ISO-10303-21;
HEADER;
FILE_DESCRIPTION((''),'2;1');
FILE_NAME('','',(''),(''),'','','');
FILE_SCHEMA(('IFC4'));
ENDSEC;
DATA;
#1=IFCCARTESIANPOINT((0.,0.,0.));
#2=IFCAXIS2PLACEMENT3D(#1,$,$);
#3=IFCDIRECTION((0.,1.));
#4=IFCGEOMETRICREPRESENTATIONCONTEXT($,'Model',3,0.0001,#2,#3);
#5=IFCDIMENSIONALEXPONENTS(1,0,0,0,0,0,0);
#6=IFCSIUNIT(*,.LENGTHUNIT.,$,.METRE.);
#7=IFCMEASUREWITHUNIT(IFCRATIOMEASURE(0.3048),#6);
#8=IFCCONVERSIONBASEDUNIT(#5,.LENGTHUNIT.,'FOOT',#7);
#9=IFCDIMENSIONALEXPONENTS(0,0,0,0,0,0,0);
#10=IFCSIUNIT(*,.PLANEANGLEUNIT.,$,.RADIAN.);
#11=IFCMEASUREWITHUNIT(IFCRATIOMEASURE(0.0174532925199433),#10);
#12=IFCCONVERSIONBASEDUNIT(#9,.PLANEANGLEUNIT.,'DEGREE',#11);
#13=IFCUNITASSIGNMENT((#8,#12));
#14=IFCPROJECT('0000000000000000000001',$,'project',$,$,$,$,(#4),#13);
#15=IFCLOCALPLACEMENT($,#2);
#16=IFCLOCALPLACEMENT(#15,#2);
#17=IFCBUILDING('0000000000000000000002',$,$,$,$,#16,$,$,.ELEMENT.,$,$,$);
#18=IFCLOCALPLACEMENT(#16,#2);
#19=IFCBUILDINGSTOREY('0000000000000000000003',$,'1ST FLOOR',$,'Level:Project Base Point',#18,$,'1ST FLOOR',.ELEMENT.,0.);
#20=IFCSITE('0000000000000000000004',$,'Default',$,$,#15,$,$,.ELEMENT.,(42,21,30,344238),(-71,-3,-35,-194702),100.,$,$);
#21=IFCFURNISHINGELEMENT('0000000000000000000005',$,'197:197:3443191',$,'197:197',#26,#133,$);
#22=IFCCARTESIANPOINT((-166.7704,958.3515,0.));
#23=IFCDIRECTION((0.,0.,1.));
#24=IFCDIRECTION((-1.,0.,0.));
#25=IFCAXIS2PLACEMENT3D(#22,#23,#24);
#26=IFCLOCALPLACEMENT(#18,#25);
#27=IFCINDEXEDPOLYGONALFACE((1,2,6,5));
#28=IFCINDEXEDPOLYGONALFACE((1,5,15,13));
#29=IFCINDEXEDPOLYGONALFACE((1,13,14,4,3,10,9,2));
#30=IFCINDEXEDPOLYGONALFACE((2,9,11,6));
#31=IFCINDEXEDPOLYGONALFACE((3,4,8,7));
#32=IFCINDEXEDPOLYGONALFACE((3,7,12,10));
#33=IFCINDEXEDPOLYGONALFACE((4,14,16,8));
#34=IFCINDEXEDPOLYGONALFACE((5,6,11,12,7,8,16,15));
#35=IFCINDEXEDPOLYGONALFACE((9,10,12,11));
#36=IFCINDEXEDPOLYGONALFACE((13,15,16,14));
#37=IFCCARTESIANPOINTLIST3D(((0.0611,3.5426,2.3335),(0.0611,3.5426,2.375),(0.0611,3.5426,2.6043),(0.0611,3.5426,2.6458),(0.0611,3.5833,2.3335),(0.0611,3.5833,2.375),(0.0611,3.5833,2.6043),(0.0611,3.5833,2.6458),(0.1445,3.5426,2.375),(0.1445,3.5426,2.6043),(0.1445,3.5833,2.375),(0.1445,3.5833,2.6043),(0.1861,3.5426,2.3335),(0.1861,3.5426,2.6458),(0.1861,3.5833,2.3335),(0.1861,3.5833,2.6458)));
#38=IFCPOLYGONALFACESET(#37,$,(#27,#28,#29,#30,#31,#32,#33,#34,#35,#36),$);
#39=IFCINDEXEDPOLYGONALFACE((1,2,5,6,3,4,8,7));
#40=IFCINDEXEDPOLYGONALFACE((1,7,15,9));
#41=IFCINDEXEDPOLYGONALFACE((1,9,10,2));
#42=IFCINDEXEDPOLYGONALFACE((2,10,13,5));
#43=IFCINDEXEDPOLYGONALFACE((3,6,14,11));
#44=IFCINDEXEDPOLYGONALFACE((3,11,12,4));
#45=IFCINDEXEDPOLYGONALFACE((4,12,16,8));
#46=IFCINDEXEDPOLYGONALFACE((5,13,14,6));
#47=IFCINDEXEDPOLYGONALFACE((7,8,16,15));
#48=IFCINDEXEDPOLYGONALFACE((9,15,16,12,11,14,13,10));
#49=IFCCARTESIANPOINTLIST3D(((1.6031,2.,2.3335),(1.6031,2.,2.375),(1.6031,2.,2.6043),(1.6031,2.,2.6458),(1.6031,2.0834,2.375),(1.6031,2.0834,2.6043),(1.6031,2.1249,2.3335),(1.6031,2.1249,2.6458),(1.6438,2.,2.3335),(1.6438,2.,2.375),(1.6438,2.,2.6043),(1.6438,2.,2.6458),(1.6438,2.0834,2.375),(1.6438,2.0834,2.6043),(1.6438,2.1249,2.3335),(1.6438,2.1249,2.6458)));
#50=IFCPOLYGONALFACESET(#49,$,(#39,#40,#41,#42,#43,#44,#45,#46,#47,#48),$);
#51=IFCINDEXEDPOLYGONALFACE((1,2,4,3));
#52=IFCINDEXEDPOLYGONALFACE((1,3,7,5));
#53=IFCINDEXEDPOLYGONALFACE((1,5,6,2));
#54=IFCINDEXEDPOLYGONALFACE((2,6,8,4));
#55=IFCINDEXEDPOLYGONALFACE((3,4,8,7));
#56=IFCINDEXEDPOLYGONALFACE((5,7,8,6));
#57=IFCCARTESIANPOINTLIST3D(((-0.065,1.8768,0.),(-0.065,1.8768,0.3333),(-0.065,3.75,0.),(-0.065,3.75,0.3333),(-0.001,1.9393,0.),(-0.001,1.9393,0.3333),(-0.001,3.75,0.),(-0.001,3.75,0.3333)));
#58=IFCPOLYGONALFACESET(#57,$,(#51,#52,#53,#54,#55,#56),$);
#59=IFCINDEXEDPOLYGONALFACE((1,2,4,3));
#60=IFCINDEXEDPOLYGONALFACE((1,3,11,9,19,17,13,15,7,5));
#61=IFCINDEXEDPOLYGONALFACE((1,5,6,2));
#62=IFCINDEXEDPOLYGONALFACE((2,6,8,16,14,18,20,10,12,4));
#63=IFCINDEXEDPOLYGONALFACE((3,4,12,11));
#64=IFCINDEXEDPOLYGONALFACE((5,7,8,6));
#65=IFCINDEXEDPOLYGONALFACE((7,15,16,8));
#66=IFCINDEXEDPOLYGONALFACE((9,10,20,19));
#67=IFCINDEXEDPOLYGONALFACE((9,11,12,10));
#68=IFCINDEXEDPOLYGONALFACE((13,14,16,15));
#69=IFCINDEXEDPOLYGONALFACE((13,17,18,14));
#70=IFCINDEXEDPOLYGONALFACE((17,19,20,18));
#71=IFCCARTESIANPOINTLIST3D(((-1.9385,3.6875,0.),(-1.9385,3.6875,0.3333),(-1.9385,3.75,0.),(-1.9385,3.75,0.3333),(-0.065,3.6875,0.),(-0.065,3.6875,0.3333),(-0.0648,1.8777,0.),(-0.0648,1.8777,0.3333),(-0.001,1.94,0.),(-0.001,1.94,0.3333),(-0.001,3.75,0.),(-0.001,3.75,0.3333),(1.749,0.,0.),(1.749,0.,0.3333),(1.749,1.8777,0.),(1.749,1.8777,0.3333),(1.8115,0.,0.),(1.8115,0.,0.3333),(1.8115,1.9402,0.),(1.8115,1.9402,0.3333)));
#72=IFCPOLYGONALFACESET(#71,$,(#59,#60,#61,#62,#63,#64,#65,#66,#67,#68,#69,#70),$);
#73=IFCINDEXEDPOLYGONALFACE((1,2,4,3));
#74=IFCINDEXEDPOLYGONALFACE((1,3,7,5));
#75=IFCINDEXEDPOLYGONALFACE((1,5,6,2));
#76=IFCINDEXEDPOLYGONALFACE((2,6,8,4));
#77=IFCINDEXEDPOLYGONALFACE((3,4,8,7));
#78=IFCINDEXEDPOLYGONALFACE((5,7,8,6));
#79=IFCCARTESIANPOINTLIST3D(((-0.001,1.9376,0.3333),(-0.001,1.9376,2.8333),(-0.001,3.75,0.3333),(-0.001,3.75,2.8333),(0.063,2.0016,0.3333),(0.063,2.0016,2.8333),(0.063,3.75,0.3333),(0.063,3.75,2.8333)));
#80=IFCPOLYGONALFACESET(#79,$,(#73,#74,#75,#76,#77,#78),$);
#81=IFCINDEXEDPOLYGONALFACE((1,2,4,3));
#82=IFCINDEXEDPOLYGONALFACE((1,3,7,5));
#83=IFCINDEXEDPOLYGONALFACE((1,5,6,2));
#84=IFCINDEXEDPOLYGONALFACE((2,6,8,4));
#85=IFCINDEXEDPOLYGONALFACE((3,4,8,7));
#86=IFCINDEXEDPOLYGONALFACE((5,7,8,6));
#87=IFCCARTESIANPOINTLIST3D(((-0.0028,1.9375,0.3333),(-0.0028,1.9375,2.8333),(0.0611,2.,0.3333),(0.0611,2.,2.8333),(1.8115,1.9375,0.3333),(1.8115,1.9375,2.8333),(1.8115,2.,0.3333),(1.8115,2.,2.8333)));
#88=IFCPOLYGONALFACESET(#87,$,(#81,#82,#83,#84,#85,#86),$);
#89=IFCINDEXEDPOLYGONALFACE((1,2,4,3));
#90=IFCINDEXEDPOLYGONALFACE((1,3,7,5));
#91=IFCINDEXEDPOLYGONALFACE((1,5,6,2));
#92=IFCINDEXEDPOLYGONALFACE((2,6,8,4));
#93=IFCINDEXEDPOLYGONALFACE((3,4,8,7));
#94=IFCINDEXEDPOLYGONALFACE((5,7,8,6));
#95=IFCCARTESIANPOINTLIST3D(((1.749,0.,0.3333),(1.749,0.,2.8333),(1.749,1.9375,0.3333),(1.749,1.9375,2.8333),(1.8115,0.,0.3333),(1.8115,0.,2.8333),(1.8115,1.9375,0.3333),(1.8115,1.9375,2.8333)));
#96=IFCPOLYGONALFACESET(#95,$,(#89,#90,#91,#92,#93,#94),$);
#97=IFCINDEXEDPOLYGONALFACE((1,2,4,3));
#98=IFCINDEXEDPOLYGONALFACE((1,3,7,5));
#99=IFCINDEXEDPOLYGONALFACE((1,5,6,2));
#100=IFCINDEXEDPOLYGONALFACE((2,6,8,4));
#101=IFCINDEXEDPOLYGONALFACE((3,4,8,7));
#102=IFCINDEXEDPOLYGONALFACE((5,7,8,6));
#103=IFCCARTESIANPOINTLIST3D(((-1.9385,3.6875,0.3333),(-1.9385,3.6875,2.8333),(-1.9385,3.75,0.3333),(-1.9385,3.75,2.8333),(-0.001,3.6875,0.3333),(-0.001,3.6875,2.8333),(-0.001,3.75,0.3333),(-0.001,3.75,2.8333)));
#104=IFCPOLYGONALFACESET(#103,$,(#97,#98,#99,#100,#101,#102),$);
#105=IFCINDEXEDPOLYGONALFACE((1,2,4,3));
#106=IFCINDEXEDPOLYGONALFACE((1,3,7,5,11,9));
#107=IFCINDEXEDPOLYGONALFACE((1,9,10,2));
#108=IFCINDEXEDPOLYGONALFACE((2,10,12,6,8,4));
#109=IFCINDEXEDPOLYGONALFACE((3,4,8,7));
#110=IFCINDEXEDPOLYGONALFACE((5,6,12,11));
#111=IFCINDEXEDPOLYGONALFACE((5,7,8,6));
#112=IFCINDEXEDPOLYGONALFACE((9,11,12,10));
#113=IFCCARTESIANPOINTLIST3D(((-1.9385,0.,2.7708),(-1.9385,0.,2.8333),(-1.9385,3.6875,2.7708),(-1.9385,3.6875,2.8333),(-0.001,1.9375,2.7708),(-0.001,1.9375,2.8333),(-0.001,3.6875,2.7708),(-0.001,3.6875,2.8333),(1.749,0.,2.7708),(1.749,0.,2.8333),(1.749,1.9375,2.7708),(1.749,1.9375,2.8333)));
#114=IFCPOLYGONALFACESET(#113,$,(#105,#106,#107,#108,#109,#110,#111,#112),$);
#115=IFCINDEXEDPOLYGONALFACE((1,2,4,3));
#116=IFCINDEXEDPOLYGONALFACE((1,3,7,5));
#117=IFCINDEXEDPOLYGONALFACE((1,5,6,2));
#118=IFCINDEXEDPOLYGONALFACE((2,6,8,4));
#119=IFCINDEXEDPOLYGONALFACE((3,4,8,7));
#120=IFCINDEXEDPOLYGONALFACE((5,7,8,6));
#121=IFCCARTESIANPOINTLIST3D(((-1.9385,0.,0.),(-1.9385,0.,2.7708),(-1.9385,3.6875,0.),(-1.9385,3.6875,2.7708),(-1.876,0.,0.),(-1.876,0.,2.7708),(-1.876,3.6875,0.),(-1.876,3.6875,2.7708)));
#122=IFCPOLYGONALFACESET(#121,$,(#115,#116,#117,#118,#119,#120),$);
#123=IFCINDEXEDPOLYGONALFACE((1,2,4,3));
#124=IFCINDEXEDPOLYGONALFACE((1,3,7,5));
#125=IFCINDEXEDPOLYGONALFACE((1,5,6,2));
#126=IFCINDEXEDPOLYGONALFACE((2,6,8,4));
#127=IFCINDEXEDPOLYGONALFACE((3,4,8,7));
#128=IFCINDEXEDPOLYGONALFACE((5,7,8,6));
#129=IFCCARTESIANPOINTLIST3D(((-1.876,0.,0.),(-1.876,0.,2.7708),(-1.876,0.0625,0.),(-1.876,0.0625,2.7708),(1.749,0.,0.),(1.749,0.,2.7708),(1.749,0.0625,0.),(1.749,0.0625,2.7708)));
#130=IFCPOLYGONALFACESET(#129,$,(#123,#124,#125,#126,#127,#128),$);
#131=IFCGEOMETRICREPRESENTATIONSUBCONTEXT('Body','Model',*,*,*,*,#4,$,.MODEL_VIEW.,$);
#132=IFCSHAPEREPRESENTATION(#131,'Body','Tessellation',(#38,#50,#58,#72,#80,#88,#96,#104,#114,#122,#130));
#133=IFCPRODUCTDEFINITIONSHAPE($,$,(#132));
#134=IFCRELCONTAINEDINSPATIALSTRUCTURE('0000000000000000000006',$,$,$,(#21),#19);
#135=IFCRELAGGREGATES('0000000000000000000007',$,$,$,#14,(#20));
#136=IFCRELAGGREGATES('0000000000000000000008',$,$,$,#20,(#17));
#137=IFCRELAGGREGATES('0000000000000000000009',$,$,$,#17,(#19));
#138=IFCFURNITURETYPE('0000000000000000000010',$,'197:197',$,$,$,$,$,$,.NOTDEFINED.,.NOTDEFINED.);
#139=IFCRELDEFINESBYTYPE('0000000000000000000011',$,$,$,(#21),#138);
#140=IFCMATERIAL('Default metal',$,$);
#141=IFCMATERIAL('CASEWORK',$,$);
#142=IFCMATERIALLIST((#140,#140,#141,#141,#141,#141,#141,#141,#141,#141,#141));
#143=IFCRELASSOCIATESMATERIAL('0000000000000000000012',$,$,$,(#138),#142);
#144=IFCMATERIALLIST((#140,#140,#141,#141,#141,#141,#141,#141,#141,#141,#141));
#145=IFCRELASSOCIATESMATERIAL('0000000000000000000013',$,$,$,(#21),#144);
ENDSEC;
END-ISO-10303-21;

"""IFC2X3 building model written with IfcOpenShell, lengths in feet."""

from ifc_helpers import new_model, entity, si_unit, converted_unit, direction, frame, frame_2d, origin, place, context, subcontext, project, spatial, polyline, rectangle, outline, extrude, source, transform, mapped, material, material_list, type_object, type_shapes, element, save


model = new_model("IFC2X3")

# Units and contexts
model_context = context("Model", 3, precision=0.0001, world=origin(), true_north=direction((0.0, 1.0)))
body_context = subcontext(model_context, "Body", "Model", "MODEL_VIEW")
ifc_project = project(units=[converted_unit("LENGTHUNIT", "FOOT", entity("IfcRatioMeasure", 0.3048), si_unit("LENGTHUNIT", "METRE"), dimensions=[1, 0, 0, 0, 0, 0, 0]), converted_unit("PLANEANGLEUNIT", "DEGREE", entity("IfcRatioMeasure", 0.0174532925199433), si_unit("PLANEANGLEUNIT", "RADIAN"), dimensions=[0, 0, 0, 0, 0, 0, 0])], contexts=[model_context])

# Site, building, storey
site_placement = place(None, origin())
site = spatial("IfcSite", under=ifc_project, at=site_placement, Name="Default", CompositionType="ELEMENT", RefLatitude=(42, 21, 30, 344238), RefLongitude=(-71, -3, -35, -194702), RefElevation=100.0)
building_placement = place(site_placement, origin())
building = spatial("IfcBuilding", under=site, at=building_placement, CompositionType="ELEMENT")
storey_placement = place(building_placement, origin())
storey = spatial("IfcBuildingStorey", under=building, at=storey_placement, Name="1ST FLOOR", ObjectType="Level:Project Base Point", LongName="1ST FLOOR", CompositionType="ELEMENT", Elevation=0.0)

# Shared definitions
ifc_material_1 = material(Name="CASEWORK")

# Furnishing element
ifc_material_2 = material(Name="Default metal")
ifc_material_list_1 = material_list([ifc_material_2, ifc_material_2, ifc_material_1, ifc_material_1, ifc_material_1, ifc_material_1, ifc_material_1, ifc_material_1, ifc_material_1, ifc_material_1, ifc_material_1])
ifc_material_list_2 = material_list([ifc_material_2, ifc_material_2, ifc_material_1, ifc_material_1, ifc_material_1, ifc_material_1, ifc_material_1, ifc_material_1, ifc_material_1, ifc_material_1, ifc_material_1])
furniture_type_1 = type_object("IfcFurnitureType", Name="197:197", material=ifc_material_list_2)
shared_shape_1 = source(origin(), body_context, "Body", "SweptSolid", [
    extrude(outline(polyline([(0.1146, -0.0521), (0.1562, -0.0521), (0.1562, 0.0729), (-0.1562, 0.0729), (-0.1562, -0.0521), (-0.1146, -0.0521), (-0.1146, 0.0313), (0.1146, 0.0313), (0.1146, -0.0521)])), frame((0.1132, 3.5426, 2.4896), z_axis=(0.0, 1.0, 0.0), x_axis=(0.0, 0.0, 1.0)), (0.0, 0.0, 1.0), 0.0407),
    extrude(outline(polyline([(-0.0521, -0.1146), (-0.0521, -0.1562), (0.0729, -0.1562), (0.0729, 0.1562), (-0.0521, 0.1562), (-0.0521, 0.1146), (0.0313, 0.1146), (0.0313, -0.1146), (-0.0521, -0.1146)])), frame((1.6031, 2.0521, 2.4896), z_axis=(-1.0, 0.0, 0.0), x_axis=(0.0, 1.0, 0.0)), (0.0, 0.0, -1.0), 0.0407),
    extrude(outline(polyline([(-0.8897, -0.032), (0.921, -0.032), (0.921, 0.032), (-0.9522, 0.032), (-0.8897, -0.032)])), frame((-0.033, 2.829, 0.0), z_axis=(0.0, 0.0, 1.0), x_axis=(0.0, 1.0, 0.0)), (0.0, 0.0, 1.0), 0.3333),
    extrude(outline(polyline([(0.3122, -1.499), (2.2497, -1.499), (2.2497, -1.4365), (0.3762, -1.4365), (0.376, 0.3734), (-1.4378, 0.3734), (-1.4378, 2.251), (-1.5003, 2.251), (-1.5003, 0.3109), (0.3122, 0.3111), (0.3122, -1.499)])), frame((0.3112, 2.251, 0.0), z_axis=(0.0, 0.0, 1.0), x_axis=(-1.0, 0.0, 0.0)), (0.0, 0.0, 1.0), 0.3333),
    extrude(outline(polyline([(-0.8582, -0.032), (0.8902, -0.032), (0.8902, 0.032), (-0.9222, 0.032), (-0.8582, -0.032)])), frame((0.031, 2.8598, 0.3333), z_axis=(0.0, 0.0, 1.0), x_axis=(0.0, 1.0, 0.0)), (0.0, 0.0, 1.0), 2.5),
    extrude(outline(polyline([(0.5927, -0.6227), (0.6822, -0.6227), (-0.6156, 0.6451), (-0.6593, 0.6004), (0.5927, -0.6227)])), frame((0.9203, 1.9687, 0.3333), z_axis=(0.0, 0.0, 1.0), x_axis=(-0.71532, -0.698797, 0.0)), (0.0, 0.0, 1.0), 2.5),
    extrude(rectangle(XDim=1.9375, YDim=0.0625, at=frame_2d((0.0, 0.0), x_axis=(1.0, 0.0))), frame((1.7802, 0.9687, 0.3333), z_axis=(0.0, 0.0, 1.0), x_axis=(0.0, -1.0, 0.0)), (0.0, 0.0, 1.0), 2.5),
    extrude(rectangle(XDim=1.9375, YDim=0.0625, at=frame_2d((0.0, 0.0), x_axis=(1.0, 0.0))), frame((-0.9698, 3.7187, 0.3333), z_axis=(0.0, 0.0, 1.0), x_axis=(-1.0, 0.0, 0.0)), (0.0, 0.0, 1.0), 2.5),
    extrude(outline(polyline([(-1.8125, -1.875), (1.875, -1.875), (1.875, 1.8125), (-0.0625, 1.8125), (-0.0625, 0.0625), (-1.8125, 0.0625), (-1.8125, -1.875)])), frame((-0.0635, 1.875, 2.7708), z_axis=(0.0, 0.0, 1.0), x_axis=(0.0, -1.0, 0.0)), (0.0, 0.0, 1.0), 0.0625),
    extrude(rectangle(XDim=3.6875, YDim=0.0625, at=frame_2d((0.0, 0.0), x_axis=(1.0, 0.0))), frame((-1.9073, 1.8438, 0.0), z_axis=(0.0, 0.0, 1.0), x_axis=(0.0, -1.0, 0.0)), (0.0, 0.0, 1.0), 2.7708),
    extrude(rectangle(XDim=3.625, YDim=0.0625, at=frame_2d((0.0, 0.0), x_axis=(1.0, 0.0))), frame((-0.0635, 0.0312, 0.0), z_axis=(0.0, 0.0, 1.0), x_axis=(-1.0, 0.0, 0.0)), (0.0, 0.0, 1.0), 2.7708),
])
type_shapes(furniture_type_1, [shared_shape_1])
furnishing_1_placement = place(storey_placement, frame((-166.7704, 958.3515, 0.0), z_axis=(0.0, 0.0, 1.0), x_axis=(-1.0, 0.0, 0.0)))
element("IfcFurnishingElement", 1, at=furnishing_1_placement, inside=storey, type_object=furniture_type_1, material=ifc_material_list_1, Name="197:197:3443191", ObjectType="197:197", context=body_context, shape_type="MappedRepresentation", body=[
    mapped(shared_shape_1, transform((0.0, 0.0, 0.0), scale=1.0)),
])

save(model, "model.ifc")
